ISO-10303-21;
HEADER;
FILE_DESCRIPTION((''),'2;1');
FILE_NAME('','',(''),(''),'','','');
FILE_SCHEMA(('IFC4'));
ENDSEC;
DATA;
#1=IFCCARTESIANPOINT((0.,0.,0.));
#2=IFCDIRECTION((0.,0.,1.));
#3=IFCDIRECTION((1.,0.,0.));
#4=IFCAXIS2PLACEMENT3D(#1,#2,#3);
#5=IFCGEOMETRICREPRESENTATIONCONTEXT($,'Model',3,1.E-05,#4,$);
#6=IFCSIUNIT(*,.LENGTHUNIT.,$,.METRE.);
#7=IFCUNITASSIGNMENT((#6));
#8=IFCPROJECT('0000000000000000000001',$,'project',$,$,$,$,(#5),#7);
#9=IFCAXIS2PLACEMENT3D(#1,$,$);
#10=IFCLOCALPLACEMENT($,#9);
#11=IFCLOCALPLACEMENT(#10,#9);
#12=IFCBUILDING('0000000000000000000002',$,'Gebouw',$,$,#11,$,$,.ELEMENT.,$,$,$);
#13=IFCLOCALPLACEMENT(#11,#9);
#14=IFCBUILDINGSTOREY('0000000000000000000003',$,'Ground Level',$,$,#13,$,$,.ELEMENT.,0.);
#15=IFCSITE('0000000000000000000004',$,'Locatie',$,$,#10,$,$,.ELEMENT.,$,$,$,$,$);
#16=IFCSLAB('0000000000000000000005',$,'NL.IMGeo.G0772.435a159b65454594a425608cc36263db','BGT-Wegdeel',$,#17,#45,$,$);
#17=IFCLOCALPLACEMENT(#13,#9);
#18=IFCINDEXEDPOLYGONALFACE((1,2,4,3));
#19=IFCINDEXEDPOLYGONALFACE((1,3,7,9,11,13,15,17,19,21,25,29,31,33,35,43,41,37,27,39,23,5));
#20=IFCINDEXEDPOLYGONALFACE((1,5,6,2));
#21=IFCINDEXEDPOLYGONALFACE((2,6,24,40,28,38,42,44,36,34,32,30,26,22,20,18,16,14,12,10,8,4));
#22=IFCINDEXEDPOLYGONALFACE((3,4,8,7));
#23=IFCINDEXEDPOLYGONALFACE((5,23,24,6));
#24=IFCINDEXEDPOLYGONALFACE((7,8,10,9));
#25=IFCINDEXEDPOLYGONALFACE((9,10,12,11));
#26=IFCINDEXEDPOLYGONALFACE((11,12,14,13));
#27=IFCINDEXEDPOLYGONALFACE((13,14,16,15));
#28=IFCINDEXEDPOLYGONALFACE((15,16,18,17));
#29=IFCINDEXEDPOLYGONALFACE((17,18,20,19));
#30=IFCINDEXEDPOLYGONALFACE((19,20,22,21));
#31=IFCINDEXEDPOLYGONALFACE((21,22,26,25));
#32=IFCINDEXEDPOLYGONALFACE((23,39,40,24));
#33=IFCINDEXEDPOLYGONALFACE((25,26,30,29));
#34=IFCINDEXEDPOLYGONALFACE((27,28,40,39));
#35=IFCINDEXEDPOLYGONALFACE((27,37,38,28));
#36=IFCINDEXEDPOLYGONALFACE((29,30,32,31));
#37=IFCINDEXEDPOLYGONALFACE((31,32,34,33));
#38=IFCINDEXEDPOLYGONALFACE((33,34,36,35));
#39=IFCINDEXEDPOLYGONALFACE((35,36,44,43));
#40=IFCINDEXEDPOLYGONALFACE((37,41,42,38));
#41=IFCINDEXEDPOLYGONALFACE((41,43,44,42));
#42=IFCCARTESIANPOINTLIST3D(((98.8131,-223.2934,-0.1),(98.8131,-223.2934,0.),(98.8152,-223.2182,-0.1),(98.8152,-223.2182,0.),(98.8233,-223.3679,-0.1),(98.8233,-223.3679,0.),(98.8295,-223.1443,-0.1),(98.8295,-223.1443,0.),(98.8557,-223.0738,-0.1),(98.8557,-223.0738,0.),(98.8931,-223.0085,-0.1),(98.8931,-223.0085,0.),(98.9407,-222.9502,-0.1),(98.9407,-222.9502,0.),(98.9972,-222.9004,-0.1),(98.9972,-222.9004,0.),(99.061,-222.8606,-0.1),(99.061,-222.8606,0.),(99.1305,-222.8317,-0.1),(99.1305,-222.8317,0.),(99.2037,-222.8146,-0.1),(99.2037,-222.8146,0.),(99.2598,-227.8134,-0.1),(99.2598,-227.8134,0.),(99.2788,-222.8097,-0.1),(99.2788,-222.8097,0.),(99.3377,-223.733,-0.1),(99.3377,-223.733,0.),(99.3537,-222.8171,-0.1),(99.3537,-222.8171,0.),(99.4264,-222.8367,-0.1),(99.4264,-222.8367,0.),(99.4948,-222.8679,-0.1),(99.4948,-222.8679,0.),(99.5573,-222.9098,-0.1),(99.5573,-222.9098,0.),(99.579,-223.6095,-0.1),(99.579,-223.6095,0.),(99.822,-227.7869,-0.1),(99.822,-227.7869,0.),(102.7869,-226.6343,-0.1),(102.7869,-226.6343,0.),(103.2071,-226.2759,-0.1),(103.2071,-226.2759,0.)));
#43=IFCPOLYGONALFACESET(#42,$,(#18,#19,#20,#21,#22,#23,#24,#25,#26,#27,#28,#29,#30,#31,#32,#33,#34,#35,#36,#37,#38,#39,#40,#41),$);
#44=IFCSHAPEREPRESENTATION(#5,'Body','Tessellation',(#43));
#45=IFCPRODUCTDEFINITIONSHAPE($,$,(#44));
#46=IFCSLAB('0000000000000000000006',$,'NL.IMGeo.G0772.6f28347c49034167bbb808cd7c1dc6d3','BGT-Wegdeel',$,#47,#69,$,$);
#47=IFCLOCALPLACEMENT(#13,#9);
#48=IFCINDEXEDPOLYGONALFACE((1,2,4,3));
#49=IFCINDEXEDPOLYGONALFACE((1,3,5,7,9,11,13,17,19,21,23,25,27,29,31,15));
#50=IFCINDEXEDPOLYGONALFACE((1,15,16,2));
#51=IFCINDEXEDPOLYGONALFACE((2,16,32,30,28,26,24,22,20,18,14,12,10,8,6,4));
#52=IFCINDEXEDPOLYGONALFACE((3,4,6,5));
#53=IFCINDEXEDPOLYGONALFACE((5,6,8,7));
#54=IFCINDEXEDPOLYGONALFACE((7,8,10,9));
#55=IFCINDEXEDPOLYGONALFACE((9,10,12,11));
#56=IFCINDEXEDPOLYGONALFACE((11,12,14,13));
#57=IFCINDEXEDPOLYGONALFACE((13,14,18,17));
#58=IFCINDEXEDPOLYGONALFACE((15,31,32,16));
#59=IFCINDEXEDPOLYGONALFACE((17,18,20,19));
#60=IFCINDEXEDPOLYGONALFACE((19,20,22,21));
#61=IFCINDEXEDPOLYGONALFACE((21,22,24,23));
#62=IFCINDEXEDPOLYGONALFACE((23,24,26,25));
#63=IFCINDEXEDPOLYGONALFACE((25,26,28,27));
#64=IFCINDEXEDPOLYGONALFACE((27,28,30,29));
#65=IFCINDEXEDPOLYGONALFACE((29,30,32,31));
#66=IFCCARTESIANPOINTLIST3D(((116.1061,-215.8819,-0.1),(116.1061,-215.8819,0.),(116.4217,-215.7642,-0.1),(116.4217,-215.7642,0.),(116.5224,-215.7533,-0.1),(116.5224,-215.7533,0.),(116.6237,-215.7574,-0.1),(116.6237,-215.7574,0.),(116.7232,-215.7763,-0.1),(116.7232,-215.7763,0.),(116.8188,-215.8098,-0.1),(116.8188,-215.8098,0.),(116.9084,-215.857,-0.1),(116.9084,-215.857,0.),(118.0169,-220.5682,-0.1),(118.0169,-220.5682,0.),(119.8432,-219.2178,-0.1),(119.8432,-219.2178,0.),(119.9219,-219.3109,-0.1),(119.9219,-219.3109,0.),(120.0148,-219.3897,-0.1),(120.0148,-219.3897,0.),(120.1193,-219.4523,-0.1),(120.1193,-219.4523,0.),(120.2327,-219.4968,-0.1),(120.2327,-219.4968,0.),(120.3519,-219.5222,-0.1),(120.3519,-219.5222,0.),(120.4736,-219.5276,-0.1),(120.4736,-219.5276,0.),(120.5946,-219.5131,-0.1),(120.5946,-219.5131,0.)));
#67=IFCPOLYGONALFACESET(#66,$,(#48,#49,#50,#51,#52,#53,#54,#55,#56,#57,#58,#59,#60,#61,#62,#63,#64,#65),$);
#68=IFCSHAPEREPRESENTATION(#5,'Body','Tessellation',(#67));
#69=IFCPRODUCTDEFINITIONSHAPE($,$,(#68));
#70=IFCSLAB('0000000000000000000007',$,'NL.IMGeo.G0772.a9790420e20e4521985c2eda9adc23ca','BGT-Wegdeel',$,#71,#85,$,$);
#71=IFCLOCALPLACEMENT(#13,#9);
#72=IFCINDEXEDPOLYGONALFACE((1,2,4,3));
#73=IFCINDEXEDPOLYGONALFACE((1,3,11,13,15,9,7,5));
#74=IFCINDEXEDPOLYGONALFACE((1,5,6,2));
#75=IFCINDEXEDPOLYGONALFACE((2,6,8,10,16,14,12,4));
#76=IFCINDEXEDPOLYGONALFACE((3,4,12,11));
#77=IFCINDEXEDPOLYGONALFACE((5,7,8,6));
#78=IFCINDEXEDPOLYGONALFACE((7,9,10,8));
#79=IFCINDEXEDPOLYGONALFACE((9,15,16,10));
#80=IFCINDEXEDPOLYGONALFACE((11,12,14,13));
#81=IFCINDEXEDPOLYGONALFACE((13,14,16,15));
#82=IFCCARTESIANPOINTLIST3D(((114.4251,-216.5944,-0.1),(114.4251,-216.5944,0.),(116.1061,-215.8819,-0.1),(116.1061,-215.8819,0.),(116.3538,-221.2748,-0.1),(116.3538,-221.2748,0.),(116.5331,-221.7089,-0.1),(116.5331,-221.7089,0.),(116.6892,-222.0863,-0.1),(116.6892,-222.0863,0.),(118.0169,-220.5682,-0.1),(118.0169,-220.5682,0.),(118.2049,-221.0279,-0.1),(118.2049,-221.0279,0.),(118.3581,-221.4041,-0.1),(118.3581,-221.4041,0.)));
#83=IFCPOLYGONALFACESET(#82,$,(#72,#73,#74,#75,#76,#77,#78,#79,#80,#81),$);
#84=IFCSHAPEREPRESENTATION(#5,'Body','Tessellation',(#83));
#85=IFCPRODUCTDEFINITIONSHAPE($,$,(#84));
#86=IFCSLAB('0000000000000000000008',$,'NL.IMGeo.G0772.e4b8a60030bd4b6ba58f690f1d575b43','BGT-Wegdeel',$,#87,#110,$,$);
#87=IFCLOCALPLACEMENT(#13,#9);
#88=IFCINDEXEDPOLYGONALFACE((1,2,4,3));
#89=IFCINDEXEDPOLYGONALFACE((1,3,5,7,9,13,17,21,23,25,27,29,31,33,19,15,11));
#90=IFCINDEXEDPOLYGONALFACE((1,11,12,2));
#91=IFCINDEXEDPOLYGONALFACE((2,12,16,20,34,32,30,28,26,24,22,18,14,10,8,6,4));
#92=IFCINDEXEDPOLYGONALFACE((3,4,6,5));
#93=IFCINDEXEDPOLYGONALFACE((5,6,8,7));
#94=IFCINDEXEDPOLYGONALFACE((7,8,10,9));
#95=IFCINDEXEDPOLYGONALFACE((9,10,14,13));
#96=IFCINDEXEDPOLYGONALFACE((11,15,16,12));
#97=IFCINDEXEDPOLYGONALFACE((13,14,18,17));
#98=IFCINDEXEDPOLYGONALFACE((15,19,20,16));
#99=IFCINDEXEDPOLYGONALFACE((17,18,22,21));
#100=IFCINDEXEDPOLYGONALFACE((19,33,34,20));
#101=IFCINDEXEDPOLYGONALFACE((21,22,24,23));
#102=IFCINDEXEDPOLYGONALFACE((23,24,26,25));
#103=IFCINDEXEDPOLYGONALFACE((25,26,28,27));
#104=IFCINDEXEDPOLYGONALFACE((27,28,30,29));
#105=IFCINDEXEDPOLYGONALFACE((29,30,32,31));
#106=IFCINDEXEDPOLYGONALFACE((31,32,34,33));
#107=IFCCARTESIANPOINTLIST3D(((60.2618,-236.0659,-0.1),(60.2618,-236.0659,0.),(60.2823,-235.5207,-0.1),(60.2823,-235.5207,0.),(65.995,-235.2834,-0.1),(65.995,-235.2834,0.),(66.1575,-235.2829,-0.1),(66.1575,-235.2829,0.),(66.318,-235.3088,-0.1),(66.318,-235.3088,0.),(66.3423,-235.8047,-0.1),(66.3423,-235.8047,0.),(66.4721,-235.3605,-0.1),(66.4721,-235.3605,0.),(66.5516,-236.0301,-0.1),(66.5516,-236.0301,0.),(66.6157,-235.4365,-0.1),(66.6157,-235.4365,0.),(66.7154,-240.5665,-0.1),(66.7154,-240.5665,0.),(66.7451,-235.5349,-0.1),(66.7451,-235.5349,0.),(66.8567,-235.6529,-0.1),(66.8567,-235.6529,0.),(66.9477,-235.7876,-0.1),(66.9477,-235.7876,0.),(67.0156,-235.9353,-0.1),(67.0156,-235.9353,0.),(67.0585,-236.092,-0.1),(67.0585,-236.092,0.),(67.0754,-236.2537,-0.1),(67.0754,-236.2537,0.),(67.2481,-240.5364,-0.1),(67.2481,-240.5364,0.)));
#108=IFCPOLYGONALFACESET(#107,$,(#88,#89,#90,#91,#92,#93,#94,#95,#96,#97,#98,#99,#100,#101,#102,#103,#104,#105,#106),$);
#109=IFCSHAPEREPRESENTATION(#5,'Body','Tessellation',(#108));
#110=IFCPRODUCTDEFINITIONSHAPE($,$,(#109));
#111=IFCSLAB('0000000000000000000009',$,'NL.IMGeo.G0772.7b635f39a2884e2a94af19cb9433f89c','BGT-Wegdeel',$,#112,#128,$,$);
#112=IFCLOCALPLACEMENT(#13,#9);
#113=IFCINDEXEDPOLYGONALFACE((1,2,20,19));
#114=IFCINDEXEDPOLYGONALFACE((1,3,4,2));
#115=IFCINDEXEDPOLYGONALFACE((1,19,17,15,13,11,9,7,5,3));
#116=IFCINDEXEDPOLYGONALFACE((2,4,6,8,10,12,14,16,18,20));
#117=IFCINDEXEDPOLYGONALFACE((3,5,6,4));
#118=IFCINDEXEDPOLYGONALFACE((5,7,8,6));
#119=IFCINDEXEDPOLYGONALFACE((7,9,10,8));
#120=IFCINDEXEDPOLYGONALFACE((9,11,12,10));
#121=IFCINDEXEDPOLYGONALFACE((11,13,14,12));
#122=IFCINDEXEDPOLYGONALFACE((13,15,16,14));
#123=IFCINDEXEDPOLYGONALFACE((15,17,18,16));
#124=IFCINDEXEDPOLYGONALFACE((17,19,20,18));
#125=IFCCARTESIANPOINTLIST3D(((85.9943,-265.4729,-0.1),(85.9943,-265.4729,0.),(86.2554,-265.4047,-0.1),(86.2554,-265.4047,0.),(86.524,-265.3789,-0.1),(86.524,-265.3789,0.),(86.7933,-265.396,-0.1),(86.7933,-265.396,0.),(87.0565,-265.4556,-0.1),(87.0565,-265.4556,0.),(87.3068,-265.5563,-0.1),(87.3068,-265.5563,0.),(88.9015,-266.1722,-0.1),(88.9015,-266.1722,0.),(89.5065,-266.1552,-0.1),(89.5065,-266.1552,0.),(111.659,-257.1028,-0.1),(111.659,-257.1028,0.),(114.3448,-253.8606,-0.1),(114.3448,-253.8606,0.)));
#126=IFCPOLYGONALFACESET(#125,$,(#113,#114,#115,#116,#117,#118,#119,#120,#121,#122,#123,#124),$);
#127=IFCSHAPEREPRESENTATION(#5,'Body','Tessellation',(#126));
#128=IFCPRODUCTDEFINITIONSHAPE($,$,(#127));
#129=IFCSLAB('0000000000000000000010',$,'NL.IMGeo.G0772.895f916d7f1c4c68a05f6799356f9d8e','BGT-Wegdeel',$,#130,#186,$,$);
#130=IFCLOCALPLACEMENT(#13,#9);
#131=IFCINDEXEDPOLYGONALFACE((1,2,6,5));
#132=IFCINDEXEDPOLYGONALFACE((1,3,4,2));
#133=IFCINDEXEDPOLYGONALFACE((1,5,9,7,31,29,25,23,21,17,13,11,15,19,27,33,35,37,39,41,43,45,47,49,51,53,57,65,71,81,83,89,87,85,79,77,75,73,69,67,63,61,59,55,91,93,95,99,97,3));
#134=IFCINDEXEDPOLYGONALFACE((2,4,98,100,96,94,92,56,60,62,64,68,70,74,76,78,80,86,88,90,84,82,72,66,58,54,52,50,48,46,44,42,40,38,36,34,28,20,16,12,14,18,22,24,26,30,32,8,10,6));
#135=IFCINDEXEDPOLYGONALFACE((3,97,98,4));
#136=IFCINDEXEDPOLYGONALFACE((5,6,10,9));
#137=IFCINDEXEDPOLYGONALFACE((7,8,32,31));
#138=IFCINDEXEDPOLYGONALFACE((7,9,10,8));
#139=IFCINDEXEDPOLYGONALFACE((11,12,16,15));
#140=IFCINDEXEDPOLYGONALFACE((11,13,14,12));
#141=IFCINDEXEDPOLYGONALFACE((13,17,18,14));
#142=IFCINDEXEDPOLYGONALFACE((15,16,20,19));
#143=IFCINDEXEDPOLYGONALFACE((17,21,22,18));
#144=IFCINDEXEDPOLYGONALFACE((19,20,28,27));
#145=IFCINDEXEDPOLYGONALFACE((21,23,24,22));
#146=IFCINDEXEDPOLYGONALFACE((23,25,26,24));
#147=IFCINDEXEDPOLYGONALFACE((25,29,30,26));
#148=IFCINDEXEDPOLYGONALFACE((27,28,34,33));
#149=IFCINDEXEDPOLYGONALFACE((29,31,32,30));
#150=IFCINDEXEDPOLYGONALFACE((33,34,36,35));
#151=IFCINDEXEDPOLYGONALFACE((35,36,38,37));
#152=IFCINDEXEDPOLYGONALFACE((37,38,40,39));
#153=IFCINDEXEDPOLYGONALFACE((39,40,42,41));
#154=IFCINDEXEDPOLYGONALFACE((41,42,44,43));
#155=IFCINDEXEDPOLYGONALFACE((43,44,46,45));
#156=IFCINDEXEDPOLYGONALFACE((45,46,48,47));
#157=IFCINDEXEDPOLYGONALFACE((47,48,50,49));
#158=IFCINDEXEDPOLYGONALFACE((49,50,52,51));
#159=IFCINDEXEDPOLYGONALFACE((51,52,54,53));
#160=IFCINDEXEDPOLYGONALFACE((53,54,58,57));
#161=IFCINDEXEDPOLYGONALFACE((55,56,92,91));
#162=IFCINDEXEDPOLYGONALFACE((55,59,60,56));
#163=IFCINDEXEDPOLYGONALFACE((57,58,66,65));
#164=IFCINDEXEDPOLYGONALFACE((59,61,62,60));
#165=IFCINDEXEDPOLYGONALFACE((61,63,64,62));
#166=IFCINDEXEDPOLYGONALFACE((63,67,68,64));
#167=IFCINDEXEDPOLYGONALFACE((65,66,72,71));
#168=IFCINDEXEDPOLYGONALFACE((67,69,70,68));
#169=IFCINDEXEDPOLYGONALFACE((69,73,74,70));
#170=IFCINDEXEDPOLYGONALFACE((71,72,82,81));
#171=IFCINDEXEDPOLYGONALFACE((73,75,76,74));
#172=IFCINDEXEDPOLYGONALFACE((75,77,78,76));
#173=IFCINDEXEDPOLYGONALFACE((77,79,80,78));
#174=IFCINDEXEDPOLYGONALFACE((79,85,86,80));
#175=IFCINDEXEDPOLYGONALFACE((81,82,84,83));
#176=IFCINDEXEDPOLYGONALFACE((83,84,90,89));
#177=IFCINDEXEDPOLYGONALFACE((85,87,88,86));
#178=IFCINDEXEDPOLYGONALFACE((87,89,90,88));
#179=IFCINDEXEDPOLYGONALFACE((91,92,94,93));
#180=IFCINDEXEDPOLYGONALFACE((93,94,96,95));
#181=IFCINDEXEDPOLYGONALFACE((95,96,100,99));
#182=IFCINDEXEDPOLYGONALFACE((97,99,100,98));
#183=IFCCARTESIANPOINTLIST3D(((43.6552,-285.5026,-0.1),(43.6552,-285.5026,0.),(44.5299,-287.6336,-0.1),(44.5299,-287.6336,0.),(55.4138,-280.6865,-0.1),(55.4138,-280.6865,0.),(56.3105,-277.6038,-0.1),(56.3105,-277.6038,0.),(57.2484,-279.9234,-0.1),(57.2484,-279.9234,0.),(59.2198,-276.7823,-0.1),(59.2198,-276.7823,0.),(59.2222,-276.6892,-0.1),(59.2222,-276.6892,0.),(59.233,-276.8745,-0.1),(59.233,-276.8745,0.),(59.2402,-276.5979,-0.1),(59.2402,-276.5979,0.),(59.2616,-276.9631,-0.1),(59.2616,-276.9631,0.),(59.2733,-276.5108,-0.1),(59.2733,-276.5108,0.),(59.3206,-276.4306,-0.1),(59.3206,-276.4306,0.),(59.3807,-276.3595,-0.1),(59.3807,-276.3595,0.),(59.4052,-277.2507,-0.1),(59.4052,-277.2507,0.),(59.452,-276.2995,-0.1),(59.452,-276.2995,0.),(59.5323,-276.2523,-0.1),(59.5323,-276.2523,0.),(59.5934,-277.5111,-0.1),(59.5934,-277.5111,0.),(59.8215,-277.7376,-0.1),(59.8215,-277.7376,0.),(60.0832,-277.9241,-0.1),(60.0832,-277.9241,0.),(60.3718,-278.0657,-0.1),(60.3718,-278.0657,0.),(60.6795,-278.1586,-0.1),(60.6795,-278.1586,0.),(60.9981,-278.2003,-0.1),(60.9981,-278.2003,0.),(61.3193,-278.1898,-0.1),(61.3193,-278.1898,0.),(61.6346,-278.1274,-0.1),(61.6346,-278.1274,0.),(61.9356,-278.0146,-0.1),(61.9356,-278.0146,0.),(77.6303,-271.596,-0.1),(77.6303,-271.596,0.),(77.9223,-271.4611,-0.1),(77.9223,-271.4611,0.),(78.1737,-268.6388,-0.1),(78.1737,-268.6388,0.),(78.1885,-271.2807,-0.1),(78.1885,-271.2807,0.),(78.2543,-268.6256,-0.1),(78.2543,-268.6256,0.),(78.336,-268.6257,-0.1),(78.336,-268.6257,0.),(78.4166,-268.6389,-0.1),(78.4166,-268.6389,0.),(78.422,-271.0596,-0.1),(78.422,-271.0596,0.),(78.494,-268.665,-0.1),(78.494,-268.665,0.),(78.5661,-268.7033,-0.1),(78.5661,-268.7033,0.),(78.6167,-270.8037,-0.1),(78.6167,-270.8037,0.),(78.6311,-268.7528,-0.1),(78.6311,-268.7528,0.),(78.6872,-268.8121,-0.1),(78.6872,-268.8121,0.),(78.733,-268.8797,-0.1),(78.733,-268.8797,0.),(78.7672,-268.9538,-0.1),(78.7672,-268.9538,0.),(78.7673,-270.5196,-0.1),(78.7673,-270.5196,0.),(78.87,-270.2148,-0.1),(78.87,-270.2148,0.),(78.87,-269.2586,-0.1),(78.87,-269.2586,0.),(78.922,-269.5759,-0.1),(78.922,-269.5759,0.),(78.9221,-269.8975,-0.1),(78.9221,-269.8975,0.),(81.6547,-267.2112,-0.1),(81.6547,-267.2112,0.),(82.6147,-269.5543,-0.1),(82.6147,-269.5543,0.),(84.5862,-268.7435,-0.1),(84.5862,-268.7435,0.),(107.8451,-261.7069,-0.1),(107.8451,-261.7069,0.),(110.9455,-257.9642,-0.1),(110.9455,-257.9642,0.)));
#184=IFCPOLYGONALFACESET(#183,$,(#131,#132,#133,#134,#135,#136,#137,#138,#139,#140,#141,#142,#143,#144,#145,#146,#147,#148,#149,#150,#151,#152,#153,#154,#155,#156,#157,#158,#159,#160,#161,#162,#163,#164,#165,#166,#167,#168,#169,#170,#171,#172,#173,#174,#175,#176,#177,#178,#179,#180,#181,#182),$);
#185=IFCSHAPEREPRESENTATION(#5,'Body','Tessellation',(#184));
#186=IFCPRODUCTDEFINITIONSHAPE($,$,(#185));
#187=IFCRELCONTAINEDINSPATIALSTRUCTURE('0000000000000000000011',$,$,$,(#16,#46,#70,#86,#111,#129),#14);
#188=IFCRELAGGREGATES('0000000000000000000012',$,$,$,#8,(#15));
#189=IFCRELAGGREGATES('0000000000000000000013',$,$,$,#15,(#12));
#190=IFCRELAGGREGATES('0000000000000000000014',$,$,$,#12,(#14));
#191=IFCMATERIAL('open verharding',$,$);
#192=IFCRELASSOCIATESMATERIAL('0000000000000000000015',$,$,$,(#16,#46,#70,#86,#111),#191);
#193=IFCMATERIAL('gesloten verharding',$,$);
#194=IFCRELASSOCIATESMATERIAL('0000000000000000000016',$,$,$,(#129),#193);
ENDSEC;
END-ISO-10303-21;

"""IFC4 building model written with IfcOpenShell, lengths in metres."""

from ifc_helpers import new_model, si_unit, frame, origin, origin_with_axes, place, context, project, spatial, polyline, outline, extrude, material, element, save


model = new_model("IFC4")

# Units and contexts
model_context = context("Model", 3, precision=1e-05, world=origin_with_axes())
ifc_project = project(units=[si_unit("LENGTHUNIT", "METRE")], contexts=[model_context])

# Site, building, storey
site_placement = place(None, origin())
site = spatial("IfcSite", under=ifc_project, at=site_placement, Name="Locatie", CompositionType="ELEMENT")
building_placement = place(site_placement, origin())
building = spatial("IfcBuilding", under=site, at=building_placement, Name="Gebouw", CompositionType="ELEMENT")
storey_placement = place(building_placement, origin())
storey = spatial("IfcBuildingStorey", under=building, at=storey_placement, Name="Ground Level", CompositionType="ELEMENT", Elevation=0.0)

# Slabs
ifc_material_1 = material(Name="open verharding")
slab_1_placement = place(storey_placement, origin())
element("IfcSlab", 1, at=slab_1_placement, inside=storey, material=ifc_material_1, Name="NL.IMGeo.G0772.435a159b65454594a425608cc36263db", Description="BGT-Wegdeel", context=model_context, shape_type="SweptSolid", body=[
    extrude(outline(polyline([(98.8233, -223.3679), (98.8131, -223.2934), (98.8152, -223.2182), (98.8295, -223.1443), (98.8557, -223.0738), (98.8931, -223.0085), (98.9407, -222.9502), (98.9972, -222.9004), (99.061, -222.8606), (99.1305, -222.8317), (99.2037, -222.8146), (99.2788, -222.8097), (99.3537, -222.8171), (99.4264, -222.8367), (99.4948, -222.8679), (99.5573, -222.9098), (103.2071, -226.2759), (102.7869, -226.6343), (99.579, -223.6095), (99.3377, -223.733), (99.822, -227.7869), (99.2598, -227.8134), (98.8233, -223.3679)])), frame((0.0, 0.0, -0.1), z_axis=(0.0, 0.0, 1.0), x_axis=(1.0, 0.0, 0.0)), (0.0, 0.0, 1.0), 0.1),
])
slab_2_placement = place(storey_placement, origin())
element("IfcSlab", 2, at=slab_2_placement, inside=storey, material=ifc_material_1, Name="NL.IMGeo.G0772.6f28347c49034167bbb808cd7c1dc6d3", Description="BGT-Wegdeel", context=model_context, shape_type="SweptSolid", body=[
    extrude(outline(polyline([(116.4217, -215.7642), (116.5224, -215.7533), (116.6237, -215.7574), (116.7232, -215.7763), (116.8188, -215.8098), (116.9084, -215.857), (119.8432, -219.2178), (119.9219, -219.3109), (120.0148, -219.3897), (120.1193, -219.4523), (120.2327, -219.4968), (120.3519, -219.5222), (120.4736, -219.5276), (120.5946, -219.5131), (118.0169, -220.5682), (116.1061, -215.8819), (116.4217, -215.7642)])), frame((0.0, 0.0, -0.1), z_axis=(0.0, 0.0, 1.0), x_axis=(1.0, 0.0, 0.0)), (0.0, 0.0, 1.0), 0.1),
])
slab_3_placement = place(storey_placement, origin())
element("IfcSlab", 3, at=slab_3_placement, inside=storey, material=ifc_material_1, Name="NL.IMGeo.G0772.a9790420e20e4521985c2eda9adc23ca", Description="BGT-Wegdeel", context=model_context, shape_type="SweptSolid", body=[
    extrude(outline(polyline([(118.0169, -220.5682), (118.2049, -221.0279), (118.3581, -221.4041), (116.6892, -222.0863), (116.5331, -221.7089), (116.3538, -221.2748), (114.4251, -216.5944), (116.1061, -215.8819), (118.0169, -220.5682)])), frame((0.0, 0.0, -0.1), z_axis=(0.0, 0.0, 1.0), x_axis=(1.0, 0.0, 0.0)), (0.0, 0.0, 1.0), 0.1),
])
slab_4_placement = place(storey_placement, origin())
element("IfcSlab", 4, at=slab_4_placement, inside=storey, material=ifc_material_1, Name="NL.IMGeo.G0772.e4b8a60030bd4b6ba58f690f1d575b43", Description="BGT-Wegdeel", context=model_context, shape_type="SweptSolid", body=[
    extrude(outline(polyline([(65.995, -235.2834), (66.1575, -235.2829), (66.318, -235.3088), (66.4721, -235.3605), (66.6157, -235.4365), (66.7451, -235.5349), (66.8567, -235.6529), (66.9477, -235.7876), (67.0156, -235.9353), (67.0585, -236.092), (67.0754, -236.2537), (67.2481, -240.5364), (66.7154, -240.5665), (66.5516, -236.0301), (66.3423, -235.8047), (60.2618, -236.0659), (60.2823, -235.5207), (65.995, -235.2834)])), frame((0.0, 0.0, -0.1), z_axis=(0.0, 0.0, 1.0), x_axis=(1.0, 0.0, 0.0)), (0.0, 0.0, 1.0), 0.1),
])
slab_5_placement = place(storey_placement, origin())
element("IfcSlab", 5, at=slab_5_placement, inside=storey, material=ifc_material_1, Name="NL.IMGeo.G0772.7b635f39a2884e2a94af19cb9433f89c", Description="BGT-Wegdeel", context=model_context, shape_type="SweptSolid", body=[
    extrude(outline(polyline([(89.5065, -266.1552), (88.9015, -266.1722), (87.3068, -265.5563), (87.0565, -265.4556), (86.7933, -265.396), (86.524, -265.3789), (86.2554, -265.4047), (85.9943, -265.4729), (114.3448, -253.8606), (111.659, -257.1028), (89.5065, -266.1552)])), frame((0.0, 0.0, -0.1), z_axis=(0.0, 0.0, 1.0), x_axis=(1.0, 0.0, 0.0)), (0.0, 0.0, 1.0), 0.1),
])
ifc_material_2 = material(Name="gesloten verharding")
slab_6_placement = place(storey_placement, origin())
element("IfcSlab", 6, at=slab_6_placement, inside=storey, material=ifc_material_2, Name="NL.IMGeo.G0772.895f916d7f1c4c68a05f6799356f9d8e", Description="BGT-Wegdeel", context=model_context, shape_type="SweptSolid", body=[
    extrude(outline(polyline([(44.5299, -287.6336), (43.6552, -285.5026), (55.4138, -280.6865), (57.2484, -279.9234), (56.3105, -277.6038), (59.5323, -276.2523), (59.452, -276.2995), (59.3807, -276.3595), (59.3206, -276.4306), (59.2733, -276.5108), (59.2402, -276.5979), (59.2222, -276.6892), (59.2198, -276.7823), (59.233, -276.8745), (59.2616, -276.9631), (59.4052, -277.2507), (59.5934, -277.5111), (59.8215, -277.7376), (60.0832, -277.9241), (60.3718, -278.0657), (60.6795, -278.1586), (60.9981, -278.2003), (61.3193, -278.1898), (61.6346, -278.1274), (61.9356, -278.0146), (77.6303, -271.596), (77.9223, -271.4611), (78.1885, -271.2807), (78.422, -271.0596), (78.6167, -270.8037), (78.7673, -270.5196), (78.87, -270.2148), (78.9221, -269.8975), (78.922, -269.5759), (78.87, -269.2586), (78.7672, -268.9538), (78.733, -268.8797), (78.6872, -268.8121), (78.6311, -268.7528), (78.5661, -268.7033), (78.494, -268.665), (78.4166, -268.6389), (78.336, -268.6257), (78.2543, -268.6256), (78.1737, -268.6388), (81.6547, -267.2112), (82.6147, -269.5543), (84.5862, -268.7435), (110.9455, -257.9642), (107.8451, -261.7069), (44.5299, -287.6336)])), frame((0.0, 0.0, -0.1), z_axis=(0.0, 0.0, 1.0), x_axis=(1.0, 0.0, 0.0)), (0.0, 0.0, 1.0), 0.1),
])

save(model, "model.ifc")
